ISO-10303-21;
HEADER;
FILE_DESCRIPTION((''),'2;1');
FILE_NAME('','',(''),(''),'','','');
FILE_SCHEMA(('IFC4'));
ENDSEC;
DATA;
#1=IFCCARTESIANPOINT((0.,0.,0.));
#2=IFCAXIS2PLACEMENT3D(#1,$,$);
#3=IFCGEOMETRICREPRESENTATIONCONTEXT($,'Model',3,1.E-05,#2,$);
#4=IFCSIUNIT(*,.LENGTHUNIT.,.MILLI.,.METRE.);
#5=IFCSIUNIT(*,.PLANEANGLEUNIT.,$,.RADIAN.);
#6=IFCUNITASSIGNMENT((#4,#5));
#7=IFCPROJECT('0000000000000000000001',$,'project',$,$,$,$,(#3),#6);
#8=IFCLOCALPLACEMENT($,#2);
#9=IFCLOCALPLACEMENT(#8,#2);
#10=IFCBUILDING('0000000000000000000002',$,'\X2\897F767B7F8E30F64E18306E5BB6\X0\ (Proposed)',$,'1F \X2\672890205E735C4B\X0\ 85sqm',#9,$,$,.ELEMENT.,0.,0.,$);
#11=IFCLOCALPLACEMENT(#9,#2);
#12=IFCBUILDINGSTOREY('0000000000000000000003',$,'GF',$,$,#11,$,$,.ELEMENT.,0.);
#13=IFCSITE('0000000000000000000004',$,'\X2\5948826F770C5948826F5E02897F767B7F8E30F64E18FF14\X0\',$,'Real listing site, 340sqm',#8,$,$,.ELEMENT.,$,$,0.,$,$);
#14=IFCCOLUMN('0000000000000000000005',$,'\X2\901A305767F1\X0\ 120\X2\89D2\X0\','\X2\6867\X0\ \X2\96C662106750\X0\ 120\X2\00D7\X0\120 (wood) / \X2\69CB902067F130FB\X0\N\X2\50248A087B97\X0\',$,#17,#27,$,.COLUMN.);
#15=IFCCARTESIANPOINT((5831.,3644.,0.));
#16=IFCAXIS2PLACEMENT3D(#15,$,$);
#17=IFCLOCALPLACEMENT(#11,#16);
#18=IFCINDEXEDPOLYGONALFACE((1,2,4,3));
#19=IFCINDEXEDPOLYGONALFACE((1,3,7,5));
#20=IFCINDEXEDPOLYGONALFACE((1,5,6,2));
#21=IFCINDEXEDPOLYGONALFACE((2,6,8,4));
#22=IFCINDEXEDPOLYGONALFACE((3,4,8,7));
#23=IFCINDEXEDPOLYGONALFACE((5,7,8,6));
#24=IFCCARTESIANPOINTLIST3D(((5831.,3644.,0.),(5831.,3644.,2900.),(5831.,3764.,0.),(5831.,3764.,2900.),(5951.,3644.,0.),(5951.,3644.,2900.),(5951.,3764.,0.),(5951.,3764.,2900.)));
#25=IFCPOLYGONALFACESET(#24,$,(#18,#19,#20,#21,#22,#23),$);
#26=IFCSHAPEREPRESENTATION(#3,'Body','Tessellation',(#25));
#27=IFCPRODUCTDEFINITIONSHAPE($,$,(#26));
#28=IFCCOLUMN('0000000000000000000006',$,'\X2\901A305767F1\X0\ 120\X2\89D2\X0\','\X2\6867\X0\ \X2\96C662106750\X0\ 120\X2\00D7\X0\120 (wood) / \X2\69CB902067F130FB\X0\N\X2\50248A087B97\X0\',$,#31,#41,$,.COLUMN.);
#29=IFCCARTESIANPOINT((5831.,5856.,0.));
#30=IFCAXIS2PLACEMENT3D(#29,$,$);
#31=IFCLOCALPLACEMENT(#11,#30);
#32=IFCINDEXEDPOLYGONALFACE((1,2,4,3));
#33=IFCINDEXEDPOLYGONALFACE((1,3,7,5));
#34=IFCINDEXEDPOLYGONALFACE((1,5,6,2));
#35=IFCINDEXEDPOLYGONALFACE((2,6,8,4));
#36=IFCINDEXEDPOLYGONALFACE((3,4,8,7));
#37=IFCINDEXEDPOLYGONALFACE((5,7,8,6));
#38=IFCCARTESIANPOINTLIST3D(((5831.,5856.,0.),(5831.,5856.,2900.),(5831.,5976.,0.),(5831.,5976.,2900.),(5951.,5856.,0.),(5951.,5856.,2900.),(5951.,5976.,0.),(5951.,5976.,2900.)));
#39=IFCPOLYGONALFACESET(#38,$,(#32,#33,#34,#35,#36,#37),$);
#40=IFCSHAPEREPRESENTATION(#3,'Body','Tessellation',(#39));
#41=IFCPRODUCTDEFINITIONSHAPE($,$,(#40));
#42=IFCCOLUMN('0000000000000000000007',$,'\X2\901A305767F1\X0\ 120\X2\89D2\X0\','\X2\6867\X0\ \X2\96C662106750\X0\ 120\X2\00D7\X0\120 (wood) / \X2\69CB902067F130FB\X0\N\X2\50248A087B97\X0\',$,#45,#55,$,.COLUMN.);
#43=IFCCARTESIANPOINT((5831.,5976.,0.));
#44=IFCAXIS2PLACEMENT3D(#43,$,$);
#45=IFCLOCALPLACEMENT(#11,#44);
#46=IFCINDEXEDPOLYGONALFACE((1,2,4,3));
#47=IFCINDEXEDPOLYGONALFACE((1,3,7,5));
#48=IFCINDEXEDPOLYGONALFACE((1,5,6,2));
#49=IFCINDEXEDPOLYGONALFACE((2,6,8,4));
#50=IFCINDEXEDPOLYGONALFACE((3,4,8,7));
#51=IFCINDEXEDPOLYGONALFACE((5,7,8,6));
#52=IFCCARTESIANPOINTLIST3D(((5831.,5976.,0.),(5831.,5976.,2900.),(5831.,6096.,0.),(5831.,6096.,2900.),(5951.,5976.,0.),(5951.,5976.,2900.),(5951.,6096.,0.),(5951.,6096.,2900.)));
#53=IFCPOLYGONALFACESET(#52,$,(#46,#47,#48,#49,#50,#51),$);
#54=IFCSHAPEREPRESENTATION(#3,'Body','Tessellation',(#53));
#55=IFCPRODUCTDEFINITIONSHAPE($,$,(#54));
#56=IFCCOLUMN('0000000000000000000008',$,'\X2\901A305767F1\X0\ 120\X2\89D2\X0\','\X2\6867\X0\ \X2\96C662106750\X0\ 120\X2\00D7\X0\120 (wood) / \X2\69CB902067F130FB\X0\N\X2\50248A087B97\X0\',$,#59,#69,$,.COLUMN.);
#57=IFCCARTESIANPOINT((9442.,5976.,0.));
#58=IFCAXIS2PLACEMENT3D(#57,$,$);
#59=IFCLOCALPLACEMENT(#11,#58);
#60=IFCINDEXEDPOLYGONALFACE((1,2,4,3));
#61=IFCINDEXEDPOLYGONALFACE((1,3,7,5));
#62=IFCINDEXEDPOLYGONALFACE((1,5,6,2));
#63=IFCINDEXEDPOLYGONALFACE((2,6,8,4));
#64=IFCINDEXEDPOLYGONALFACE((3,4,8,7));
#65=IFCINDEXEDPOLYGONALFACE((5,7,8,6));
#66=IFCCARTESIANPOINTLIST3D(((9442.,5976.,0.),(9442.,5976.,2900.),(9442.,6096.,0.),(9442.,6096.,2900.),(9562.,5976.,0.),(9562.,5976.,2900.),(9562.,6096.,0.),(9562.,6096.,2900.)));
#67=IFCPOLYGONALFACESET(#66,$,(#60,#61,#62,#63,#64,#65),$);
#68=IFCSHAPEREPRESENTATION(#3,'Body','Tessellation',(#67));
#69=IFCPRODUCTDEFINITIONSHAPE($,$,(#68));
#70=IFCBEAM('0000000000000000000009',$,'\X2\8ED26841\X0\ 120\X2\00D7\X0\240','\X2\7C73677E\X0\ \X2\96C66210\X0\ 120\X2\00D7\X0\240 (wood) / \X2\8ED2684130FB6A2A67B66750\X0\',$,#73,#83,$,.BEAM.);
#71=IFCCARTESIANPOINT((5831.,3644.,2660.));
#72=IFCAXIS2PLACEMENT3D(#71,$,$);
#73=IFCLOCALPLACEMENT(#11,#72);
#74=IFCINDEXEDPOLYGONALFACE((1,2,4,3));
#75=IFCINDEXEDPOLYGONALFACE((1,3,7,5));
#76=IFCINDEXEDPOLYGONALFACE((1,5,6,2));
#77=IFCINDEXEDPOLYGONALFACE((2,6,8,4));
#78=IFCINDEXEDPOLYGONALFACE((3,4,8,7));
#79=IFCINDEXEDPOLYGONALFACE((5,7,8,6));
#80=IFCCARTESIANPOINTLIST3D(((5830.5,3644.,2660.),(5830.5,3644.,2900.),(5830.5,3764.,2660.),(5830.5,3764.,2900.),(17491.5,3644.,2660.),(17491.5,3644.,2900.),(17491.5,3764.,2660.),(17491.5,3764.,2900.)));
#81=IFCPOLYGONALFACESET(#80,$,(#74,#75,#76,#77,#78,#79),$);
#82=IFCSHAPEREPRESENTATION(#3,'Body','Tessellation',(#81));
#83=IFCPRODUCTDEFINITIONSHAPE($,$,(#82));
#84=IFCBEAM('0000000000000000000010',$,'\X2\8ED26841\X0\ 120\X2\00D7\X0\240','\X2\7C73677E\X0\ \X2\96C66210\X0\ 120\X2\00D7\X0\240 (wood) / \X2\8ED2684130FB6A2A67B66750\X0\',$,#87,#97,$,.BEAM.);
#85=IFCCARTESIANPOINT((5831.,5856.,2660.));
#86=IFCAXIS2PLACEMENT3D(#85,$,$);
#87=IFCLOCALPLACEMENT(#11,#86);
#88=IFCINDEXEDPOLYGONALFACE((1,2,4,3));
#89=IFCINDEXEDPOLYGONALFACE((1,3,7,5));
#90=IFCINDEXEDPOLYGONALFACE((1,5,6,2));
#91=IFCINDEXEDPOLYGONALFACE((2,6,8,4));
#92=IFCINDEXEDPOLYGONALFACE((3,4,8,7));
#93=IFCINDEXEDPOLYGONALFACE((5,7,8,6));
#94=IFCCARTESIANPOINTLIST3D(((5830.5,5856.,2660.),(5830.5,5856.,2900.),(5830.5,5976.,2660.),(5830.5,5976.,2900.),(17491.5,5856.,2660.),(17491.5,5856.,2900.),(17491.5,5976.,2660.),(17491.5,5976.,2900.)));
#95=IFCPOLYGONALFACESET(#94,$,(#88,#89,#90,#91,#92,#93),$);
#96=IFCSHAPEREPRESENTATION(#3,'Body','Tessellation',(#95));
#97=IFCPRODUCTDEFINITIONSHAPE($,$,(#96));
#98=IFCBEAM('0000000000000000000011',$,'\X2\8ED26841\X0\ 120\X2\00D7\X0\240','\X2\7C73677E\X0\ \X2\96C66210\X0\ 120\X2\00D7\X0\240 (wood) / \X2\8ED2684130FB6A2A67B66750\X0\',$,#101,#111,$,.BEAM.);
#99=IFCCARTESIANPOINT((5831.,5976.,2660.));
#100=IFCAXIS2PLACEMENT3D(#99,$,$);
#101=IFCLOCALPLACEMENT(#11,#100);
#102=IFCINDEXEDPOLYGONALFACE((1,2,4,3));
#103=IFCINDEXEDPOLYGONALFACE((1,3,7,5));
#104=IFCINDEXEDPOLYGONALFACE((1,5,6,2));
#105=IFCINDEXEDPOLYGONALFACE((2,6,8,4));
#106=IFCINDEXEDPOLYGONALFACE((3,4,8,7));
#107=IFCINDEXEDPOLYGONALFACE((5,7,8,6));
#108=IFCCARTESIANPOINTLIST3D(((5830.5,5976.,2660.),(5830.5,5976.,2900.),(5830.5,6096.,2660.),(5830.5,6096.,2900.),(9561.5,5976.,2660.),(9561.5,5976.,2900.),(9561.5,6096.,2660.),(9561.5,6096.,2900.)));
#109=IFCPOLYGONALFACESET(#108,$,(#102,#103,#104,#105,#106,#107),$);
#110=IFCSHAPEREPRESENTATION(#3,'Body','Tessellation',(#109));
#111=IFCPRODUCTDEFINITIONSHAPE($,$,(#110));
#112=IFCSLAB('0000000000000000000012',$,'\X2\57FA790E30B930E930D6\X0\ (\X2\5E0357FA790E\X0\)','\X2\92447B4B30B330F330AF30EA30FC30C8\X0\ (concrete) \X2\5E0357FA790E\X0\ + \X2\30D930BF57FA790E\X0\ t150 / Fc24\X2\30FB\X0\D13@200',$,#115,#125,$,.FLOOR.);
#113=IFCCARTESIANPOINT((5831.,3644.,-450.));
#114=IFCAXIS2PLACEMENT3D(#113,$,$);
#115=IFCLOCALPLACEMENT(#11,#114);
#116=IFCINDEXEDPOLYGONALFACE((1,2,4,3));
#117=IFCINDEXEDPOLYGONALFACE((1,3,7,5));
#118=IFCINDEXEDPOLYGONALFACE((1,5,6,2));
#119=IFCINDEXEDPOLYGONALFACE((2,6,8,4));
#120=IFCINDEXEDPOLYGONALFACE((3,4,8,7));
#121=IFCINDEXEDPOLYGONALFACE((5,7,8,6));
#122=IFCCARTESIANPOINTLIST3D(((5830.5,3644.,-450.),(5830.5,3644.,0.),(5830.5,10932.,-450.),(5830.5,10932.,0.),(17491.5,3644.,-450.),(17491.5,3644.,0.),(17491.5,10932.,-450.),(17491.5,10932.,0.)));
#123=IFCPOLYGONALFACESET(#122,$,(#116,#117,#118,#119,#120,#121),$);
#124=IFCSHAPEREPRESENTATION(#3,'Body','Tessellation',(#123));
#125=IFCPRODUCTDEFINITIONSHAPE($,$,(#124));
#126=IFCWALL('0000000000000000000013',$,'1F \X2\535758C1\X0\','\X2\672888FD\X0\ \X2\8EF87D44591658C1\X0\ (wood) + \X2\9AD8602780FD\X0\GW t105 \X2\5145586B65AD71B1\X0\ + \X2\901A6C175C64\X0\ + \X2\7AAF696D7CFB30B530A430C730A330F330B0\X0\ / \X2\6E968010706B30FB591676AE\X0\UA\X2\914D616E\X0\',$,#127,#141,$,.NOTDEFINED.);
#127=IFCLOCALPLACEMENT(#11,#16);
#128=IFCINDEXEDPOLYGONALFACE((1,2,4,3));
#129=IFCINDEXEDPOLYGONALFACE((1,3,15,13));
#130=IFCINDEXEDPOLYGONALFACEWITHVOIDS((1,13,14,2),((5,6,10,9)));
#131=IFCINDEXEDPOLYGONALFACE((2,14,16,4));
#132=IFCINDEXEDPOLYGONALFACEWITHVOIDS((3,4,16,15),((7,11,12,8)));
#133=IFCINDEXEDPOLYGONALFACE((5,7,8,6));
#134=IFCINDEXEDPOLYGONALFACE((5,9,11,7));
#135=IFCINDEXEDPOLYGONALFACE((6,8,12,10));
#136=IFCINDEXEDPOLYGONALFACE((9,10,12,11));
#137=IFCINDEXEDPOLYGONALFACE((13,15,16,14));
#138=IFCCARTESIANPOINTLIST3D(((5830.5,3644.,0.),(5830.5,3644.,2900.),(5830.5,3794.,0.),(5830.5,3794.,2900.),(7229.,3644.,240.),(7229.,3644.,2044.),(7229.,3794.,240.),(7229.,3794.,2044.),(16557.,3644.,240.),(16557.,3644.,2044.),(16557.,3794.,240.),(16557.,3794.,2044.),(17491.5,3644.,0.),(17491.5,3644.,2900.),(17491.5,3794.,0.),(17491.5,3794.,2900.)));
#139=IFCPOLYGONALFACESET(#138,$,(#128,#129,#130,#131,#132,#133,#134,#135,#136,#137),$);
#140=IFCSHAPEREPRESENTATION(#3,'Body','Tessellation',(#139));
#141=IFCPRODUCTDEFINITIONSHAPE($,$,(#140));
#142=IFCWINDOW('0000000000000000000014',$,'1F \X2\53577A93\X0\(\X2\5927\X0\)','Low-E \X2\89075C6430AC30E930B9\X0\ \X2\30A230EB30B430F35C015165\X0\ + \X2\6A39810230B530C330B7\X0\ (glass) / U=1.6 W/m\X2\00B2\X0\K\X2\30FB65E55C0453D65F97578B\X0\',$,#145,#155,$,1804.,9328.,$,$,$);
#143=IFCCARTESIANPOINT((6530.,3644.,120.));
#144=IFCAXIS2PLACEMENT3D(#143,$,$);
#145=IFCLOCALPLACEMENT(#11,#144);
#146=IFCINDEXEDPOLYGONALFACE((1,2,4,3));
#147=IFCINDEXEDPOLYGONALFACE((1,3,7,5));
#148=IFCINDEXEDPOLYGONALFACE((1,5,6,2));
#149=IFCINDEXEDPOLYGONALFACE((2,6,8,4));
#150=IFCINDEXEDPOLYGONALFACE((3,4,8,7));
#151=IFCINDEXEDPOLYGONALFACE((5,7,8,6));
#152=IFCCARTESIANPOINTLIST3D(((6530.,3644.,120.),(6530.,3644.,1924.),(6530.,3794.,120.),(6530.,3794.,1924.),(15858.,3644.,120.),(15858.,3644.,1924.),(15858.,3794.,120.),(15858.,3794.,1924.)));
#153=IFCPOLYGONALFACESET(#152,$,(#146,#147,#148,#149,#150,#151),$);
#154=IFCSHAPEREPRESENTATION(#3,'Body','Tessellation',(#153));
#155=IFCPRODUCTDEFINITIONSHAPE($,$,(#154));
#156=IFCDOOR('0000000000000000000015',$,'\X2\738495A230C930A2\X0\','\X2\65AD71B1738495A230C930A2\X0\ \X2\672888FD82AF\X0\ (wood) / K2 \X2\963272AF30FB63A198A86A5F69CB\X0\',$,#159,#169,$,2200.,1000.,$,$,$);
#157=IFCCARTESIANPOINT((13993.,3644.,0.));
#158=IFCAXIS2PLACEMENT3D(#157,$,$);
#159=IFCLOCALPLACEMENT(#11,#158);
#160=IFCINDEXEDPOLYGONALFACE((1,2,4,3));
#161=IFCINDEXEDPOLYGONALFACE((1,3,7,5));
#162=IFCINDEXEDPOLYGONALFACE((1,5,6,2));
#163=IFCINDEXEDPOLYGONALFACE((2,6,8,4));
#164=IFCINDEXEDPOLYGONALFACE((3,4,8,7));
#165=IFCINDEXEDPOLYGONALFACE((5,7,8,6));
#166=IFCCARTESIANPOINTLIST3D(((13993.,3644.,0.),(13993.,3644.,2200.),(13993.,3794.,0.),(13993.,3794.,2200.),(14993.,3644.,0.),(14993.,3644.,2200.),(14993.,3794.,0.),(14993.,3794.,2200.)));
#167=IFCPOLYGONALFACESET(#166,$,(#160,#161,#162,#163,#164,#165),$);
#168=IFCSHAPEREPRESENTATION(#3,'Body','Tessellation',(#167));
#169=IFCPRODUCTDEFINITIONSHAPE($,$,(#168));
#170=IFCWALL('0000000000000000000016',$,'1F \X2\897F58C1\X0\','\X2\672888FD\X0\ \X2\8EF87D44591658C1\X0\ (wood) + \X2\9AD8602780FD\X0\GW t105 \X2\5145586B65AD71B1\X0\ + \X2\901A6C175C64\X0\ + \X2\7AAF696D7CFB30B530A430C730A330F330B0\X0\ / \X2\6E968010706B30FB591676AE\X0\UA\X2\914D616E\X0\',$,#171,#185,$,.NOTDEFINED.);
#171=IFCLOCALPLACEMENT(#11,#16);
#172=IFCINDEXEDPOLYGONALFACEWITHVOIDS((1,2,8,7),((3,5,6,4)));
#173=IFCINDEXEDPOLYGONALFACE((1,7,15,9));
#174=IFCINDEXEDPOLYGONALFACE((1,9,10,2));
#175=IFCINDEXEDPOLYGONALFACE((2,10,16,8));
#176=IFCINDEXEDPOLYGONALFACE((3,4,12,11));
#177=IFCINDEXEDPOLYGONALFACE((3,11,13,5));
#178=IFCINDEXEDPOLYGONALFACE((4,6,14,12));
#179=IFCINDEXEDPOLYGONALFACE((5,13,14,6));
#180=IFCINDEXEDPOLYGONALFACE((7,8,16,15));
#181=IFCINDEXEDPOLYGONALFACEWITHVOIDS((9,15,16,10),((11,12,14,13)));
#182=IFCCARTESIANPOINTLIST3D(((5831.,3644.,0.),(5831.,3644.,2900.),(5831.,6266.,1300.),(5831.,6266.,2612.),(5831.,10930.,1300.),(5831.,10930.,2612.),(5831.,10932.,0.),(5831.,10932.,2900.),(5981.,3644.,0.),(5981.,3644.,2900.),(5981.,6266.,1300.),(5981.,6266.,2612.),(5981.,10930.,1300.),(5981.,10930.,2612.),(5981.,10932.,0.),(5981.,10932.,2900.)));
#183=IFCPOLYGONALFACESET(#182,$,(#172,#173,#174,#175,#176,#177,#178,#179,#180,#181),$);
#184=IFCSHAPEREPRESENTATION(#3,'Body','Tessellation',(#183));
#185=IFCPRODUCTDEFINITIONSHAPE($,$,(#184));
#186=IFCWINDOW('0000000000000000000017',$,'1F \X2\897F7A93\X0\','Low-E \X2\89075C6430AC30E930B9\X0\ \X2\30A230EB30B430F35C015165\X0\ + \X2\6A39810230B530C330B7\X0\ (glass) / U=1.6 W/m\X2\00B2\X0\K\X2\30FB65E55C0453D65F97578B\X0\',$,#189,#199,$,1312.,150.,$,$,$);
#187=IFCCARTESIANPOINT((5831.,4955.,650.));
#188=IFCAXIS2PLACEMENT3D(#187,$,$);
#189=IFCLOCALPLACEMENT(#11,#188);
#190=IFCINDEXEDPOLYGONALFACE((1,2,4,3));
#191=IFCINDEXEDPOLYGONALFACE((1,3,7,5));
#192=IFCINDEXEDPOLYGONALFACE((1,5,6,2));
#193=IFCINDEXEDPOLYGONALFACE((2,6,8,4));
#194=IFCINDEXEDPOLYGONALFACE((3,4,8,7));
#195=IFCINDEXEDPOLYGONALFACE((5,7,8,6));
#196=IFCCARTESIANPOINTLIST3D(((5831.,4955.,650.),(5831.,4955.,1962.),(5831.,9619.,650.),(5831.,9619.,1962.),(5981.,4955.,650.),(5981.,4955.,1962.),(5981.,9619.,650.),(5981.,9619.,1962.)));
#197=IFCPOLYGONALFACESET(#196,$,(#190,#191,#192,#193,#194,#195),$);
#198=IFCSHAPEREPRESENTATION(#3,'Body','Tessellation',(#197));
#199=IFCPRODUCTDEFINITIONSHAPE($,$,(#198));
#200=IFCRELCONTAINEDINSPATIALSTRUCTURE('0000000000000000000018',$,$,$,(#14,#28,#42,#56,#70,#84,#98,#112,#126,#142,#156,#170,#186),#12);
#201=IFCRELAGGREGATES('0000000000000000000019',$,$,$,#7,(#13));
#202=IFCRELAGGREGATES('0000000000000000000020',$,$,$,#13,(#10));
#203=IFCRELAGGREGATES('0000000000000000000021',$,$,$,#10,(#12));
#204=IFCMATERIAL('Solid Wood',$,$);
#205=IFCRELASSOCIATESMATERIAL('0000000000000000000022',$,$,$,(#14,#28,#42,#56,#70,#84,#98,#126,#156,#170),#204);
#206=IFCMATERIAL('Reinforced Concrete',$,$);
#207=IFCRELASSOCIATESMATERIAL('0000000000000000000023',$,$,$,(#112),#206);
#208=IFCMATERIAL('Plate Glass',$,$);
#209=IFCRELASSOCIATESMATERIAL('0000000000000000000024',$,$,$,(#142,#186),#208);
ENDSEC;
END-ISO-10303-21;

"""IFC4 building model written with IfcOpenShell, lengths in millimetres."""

from ifc_helpers import new_model, si_unit, frame, frame_2d, origin, place, context, project, spatial, rectangle, extrude, material, element, fill, save


model = new_model("IFC4")

# Units and contexts
model_context = context("Model", 3, precision=1e-05, world=origin())
ifc_project = project(units=[si_unit("LENGTHUNIT", "METRE", prefix="MILLI"), si_unit("PLANEANGLEUNIT", "RADIAN")], contexts=[model_context])

# Site, building, storey
site_placement = place(None, origin())
site = spatial("IfcSite", under=ifc_project, at=site_placement, Name="奈良県奈良市西登美ヶ丘４", ObjectType="Real listing site, 340sqm", CompositionType="ELEMENT", RefElevation=0.0)
building_placement = place(site_placement, origin())
building = spatial("IfcBuilding", under=site, at=building_placement, Name="西登美ヶ丘の家 (Proposed)", ObjectType="1F 木造平屋 85sqm", CompositionType="ELEMENT", ElevationOfRefHeight=0.0, ElevationOfTerrain=0.0)
storey_placement = place(building_placement, origin())
storey = spatial("IfcBuildingStorey", under=building, at=storey_placement, Name="GF", CompositionType="ELEMENT", Elevation=0.0)

# Columns
ifc_material_1 = material(Name="Solid Wood")
column_1_placement = place(storey_placement, frame((5831.0, 3644.0, 0.0)))
element("IfcColumn", 1, at=column_1_placement, inside=storey, material=ifc_material_1, Name="通し柱 120角", Description="桧 集成材 120×120 (wood) / 構造柱・N値計算", PredefinedType="COLUMN", context=model_context, shape_type="SweptSolid", body=[
    extrude(rectangle(XDim=120.0, YDim=120.0, at=frame_2d((60.0, 60.0))), frame((5831.0, 3644.0, 0.0)), (0.0, 0.0, 1.0), 2900.0),
])
column_2_placement = place(storey_placement, frame((5831.0, 5856.0, 0.0)))
element("IfcColumn", 2, at=column_2_placement, inside=storey, material=ifc_material_1, Name="通し柱 120角", Description="桧 集成材 120×120 (wood) / 構造柱・N値計算", PredefinedType="COLUMN", context=model_context, shape_type="SweptSolid", body=[
    extrude(rectangle(XDim=120.0, YDim=120.0, at=frame_2d((60.0, 60.0))), frame((5831.0, 5856.0, 0.0)), (0.0, 0.0, 1.0), 2900.0),
])
column_3_placement = place(storey_placement, frame((5831.0, 5976.0, 0.0)))
element("IfcColumn", 3, at=column_3_placement, inside=storey, material=ifc_material_1, Name="通し柱 120角", Description="桧 集成材 120×120 (wood) / 構造柱・N値計算", PredefinedType="COLUMN", context=model_context, shape_type="SweptSolid", body=[
    extrude(rectangle(XDim=120.0, YDim=120.0, at=frame_2d((60.0, 60.0))), frame((5831.0, 5976.0, 0.0)), (0.0, 0.0, 1.0), 2900.0),
])
column_4_placement = place(storey_placement, frame((9442.0, 5976.0, 0.0)))
element("IfcColumn", 4, at=column_4_placement, inside=storey, material=ifc_material_1, Name="通し柱 120角", Description="桧 集成材 120×120 (wood) / 構造柱・N値計算", PredefinedType="COLUMN", context=model_context, shape_type="SweptSolid", body=[
    extrude(rectangle(XDim=120.0, YDim=120.0, at=frame_2d((60.0, 60.0))), frame((9442.0, 5976.0, 0.0)), (0.0, 0.0, 1.0), 2900.0),
])

# Beams
beam_1_placement = place(storey_placement, frame((5831.0, 3644.0, 2660.0)))
element("IfcBeam", 5, at=beam_1_placement, inside=storey, material=ifc_material_1, Name="軒桁 120×240", Description="米松 集成 120×240 (wood) / 軒桁・横架材", PredefinedType="BEAM", context=model_context, shape_type="SweptSolid", body=[
    extrude(rectangle(XDim=11661.0, YDim=120.0, at=frame_2d((5830.0, 60.0))), frame((5831.0, 3644.0, 2660.0)), (0.0, 0.0, 1.0), 240.0),
])
beam_2_placement = place(storey_placement, frame((5831.0, 5856.0, 2660.0)))
element("IfcBeam", 6, at=beam_2_placement, inside=storey, material=ifc_material_1, Name="軒桁 120×240", Description="米松 集成 120×240 (wood) / 軒桁・横架材", PredefinedType="BEAM", context=model_context, shape_type="SweptSolid", body=[
    extrude(rectangle(XDim=11661.0, YDim=120.0, at=frame_2d((5830.0, 60.0))), frame((5831.0, 5856.0, 2660.0)), (0.0, 0.0, 1.0), 240.0),
])
beam_3_placement = place(storey_placement, frame((5831.0, 5976.0, 2660.0)))
element("IfcBeam", 7, at=beam_3_placement, inside=storey, material=ifc_material_1, Name="軒桁 120×240", Description="米松 集成 120×240 (wood) / 軒桁・横架材", PredefinedType="BEAM", context=model_context, shape_type="SweptSolid", body=[
    extrude(rectangle(XDim=3731.0, YDim=120.0, at=frame_2d((1865.0, 60.0))), frame((5831.0, 5976.0, 2660.0)), (0.0, 0.0, 1.0), 240.0),
])

# Slab
ifc_material_2 = material(Name="Reinforced Concrete")
slab_1_placement = place(storey_placement, frame((5831.0, 3644.0, -450.0)))
element("IfcSlab", 8, at=slab_1_placement, inside=storey, material=ifc_material_2, Name="基礎スラブ (布基礎)", Description="鉄筋コンクリート (concrete) 布基礎 + ベタ基礎 t150 / Fc24・D13@200", PredefinedType="FLOOR", context=model_context, shape_type="SweptSolid", body=[
    extrude(rectangle(XDim=11661.0, YDim=7288.0, at=frame_2d((5830.0, 3644.0))), frame((5831.0, 3644.0, -450.0)), (0.0, 0.0, 1.0), 450.0),
])

# Wall, openings, window, door
wall_1_placement = place(storey_placement, frame((5831.0, 3644.0, 0.0)))
wall_1 = element("IfcWall", 9, at=wall_1_placement, inside=storey, material=ifc_material_1, Name="1F 南壁", Description="木製 軸組外壁 (wood) + 高性能GW t105 充填断熱 + 通気層 + 窯業系サイディング / 準耐火・外皮UA配慮", PredefinedType="NOTDEFINED", context=model_context, shape_type="SweptSolid", body=[
    extrude(rectangle(XDim=11661.0, YDim=150.0, at=frame_2d((5830.0, 75.0))), frame((5831.0, 3644.0, 0.0)), (0.0, 0.0, 1.0), 2900.0),
])
opening_1_placement = place(storey_placement, frame((6530.0, 3644.0, 120.0)))
opening_1 = element("IfcOpeningElement", 10, at=opening_1_placement, cuts=wall_1, PredefinedType="NOTDEFINED", context=model_context, shape_type="SweptSolid", body=[
    extrude(rectangle(XDim=9328.0, YDim=150.0, at=frame_2d((4664.0, 75.0))), frame((6530.0, 3644.0, 120.0)), (0.0, 0.0, 1.0), 1804.0),
])
opening_2_placement = place(storey_placement, frame((13993.0, 3644.0, 0.0)))
opening_2 = element("IfcOpeningElement", 11, at=opening_2_placement, cuts=wall_1, PredefinedType="NOTDEFINED", context=model_context, shape_type="SweptSolid", body=[
    extrude(rectangle(XDim=1000.0, YDim=150.0, at=frame_2d((500.0, 75.0))), frame((13993.0, 3644.0, 0.0)), (0.0, 0.0, 1.0), 2200.0),
])
ifc_material_3 = material(Name="Plate Glass")
window_1_placement = place(storey_placement, frame((6530.0, 3644.0, 120.0)))
window_1 = element("IfcWindow", 12, at=window_1_placement, inside=storey, material=ifc_material_3, Name="1F 南窓(大)", Description="Low-E 複層ガラス アルゴン封入 + 樹脂サッシ (glass) / U=1.6 W/m²K・日射取得型", OverallHeight=1804.0, OverallWidth=9328.0, context=model_context, shape_type="SweptSolid", body=[
    extrude(rectangle(XDim=9328.0, YDim=150.0, at=frame_2d((4664.0, 75.0))), frame((6530.0, 3644.0, 120.0)), (0.0, 0.0, 1.0), 1804.0),
])
fill(opening_1, window_1)
door_placement = place(storey_placement, frame((13993.0, 3644.0, 0.0)))
door = element("IfcDoor", 13, at=door_placement, inside=storey, material=ifc_material_1, Name="玄関ドア", Description="断熱玄関ドア 木製芯 (wood) / K2 防犯・採風機構", OverallHeight=2200.0, OverallWidth=1000.0, context=model_context, shape_type="SweptSolid", body=[
    extrude(rectangle(XDim=1000.0, YDim=150.0, at=frame_2d((500.0, 75.0))), frame((13993.0, 3644.0, 0.0)), (0.0, 0.0, 1.0), 2200.0),
])
fill(opening_2, door)

# Wall, opening, window
wall_2_placement = place(storey_placement, frame((5831.0, 3644.0, 0.0)))
wall_2 = element("IfcWall", 14, at=wall_2_placement, inside=storey, material=ifc_material_1, Name="1F 西壁", Description="木製 軸組外壁 (wood) + 高性能GW t105 充填断熱 + 通気層 + 窯業系サイディング / 準耐火・外皮UA配慮", PredefinedType="NOTDEFINED", context=model_context, shape_type="SweptSolid", body=[
    extrude(rectangle(XDim=150.0, YDim=7288.0, at=frame_2d((75.0, 3644.0))), frame((5831.0, 3644.0, 0.0)), (0.0, 0.0, 1.0), 2900.0),
])
opening_3_placement = place(storey_placement, frame((5831.0, 4955.0, 650.0)))
opening_3 = element("IfcOpeningElement", 15, at=opening_3_placement, cuts=wall_2, PredefinedType="NOTDEFINED", context=model_context, shape_type="SweptSolid", body=[
    extrude(rectangle(XDim=150.0, YDim=4664.0, at=frame_2d((75.0, 2332.0))), frame((5831.0, 4955.0, 650.0)), (0.0, 0.0, 1.0), 1312.0),
])
window_2_placement = place(storey_placement, frame((5831.0, 4955.0, 650.0)))
window_2 = element("IfcWindow", 16, at=window_2_placement, inside=storey, material=ifc_material_3, Name="1F 西窓", Description="Low-E 複層ガラス アルゴン封入 + 樹脂サッシ (glass) / U=1.6 W/m²K・日射取得型", OverallHeight=1312.0, OverallWidth=150.0, context=model_context, shape_type="SweptSolid", body=[
    extrude(rectangle(XDim=150.0, YDim=4664.0, at=frame_2d((75.0, 2332.0))), frame((5831.0, 4955.0, 650.0)), (0.0, 0.0, 1.0), 1312.0),
])
fill(opening_3, window_2)

save(model, "model.ifc")
